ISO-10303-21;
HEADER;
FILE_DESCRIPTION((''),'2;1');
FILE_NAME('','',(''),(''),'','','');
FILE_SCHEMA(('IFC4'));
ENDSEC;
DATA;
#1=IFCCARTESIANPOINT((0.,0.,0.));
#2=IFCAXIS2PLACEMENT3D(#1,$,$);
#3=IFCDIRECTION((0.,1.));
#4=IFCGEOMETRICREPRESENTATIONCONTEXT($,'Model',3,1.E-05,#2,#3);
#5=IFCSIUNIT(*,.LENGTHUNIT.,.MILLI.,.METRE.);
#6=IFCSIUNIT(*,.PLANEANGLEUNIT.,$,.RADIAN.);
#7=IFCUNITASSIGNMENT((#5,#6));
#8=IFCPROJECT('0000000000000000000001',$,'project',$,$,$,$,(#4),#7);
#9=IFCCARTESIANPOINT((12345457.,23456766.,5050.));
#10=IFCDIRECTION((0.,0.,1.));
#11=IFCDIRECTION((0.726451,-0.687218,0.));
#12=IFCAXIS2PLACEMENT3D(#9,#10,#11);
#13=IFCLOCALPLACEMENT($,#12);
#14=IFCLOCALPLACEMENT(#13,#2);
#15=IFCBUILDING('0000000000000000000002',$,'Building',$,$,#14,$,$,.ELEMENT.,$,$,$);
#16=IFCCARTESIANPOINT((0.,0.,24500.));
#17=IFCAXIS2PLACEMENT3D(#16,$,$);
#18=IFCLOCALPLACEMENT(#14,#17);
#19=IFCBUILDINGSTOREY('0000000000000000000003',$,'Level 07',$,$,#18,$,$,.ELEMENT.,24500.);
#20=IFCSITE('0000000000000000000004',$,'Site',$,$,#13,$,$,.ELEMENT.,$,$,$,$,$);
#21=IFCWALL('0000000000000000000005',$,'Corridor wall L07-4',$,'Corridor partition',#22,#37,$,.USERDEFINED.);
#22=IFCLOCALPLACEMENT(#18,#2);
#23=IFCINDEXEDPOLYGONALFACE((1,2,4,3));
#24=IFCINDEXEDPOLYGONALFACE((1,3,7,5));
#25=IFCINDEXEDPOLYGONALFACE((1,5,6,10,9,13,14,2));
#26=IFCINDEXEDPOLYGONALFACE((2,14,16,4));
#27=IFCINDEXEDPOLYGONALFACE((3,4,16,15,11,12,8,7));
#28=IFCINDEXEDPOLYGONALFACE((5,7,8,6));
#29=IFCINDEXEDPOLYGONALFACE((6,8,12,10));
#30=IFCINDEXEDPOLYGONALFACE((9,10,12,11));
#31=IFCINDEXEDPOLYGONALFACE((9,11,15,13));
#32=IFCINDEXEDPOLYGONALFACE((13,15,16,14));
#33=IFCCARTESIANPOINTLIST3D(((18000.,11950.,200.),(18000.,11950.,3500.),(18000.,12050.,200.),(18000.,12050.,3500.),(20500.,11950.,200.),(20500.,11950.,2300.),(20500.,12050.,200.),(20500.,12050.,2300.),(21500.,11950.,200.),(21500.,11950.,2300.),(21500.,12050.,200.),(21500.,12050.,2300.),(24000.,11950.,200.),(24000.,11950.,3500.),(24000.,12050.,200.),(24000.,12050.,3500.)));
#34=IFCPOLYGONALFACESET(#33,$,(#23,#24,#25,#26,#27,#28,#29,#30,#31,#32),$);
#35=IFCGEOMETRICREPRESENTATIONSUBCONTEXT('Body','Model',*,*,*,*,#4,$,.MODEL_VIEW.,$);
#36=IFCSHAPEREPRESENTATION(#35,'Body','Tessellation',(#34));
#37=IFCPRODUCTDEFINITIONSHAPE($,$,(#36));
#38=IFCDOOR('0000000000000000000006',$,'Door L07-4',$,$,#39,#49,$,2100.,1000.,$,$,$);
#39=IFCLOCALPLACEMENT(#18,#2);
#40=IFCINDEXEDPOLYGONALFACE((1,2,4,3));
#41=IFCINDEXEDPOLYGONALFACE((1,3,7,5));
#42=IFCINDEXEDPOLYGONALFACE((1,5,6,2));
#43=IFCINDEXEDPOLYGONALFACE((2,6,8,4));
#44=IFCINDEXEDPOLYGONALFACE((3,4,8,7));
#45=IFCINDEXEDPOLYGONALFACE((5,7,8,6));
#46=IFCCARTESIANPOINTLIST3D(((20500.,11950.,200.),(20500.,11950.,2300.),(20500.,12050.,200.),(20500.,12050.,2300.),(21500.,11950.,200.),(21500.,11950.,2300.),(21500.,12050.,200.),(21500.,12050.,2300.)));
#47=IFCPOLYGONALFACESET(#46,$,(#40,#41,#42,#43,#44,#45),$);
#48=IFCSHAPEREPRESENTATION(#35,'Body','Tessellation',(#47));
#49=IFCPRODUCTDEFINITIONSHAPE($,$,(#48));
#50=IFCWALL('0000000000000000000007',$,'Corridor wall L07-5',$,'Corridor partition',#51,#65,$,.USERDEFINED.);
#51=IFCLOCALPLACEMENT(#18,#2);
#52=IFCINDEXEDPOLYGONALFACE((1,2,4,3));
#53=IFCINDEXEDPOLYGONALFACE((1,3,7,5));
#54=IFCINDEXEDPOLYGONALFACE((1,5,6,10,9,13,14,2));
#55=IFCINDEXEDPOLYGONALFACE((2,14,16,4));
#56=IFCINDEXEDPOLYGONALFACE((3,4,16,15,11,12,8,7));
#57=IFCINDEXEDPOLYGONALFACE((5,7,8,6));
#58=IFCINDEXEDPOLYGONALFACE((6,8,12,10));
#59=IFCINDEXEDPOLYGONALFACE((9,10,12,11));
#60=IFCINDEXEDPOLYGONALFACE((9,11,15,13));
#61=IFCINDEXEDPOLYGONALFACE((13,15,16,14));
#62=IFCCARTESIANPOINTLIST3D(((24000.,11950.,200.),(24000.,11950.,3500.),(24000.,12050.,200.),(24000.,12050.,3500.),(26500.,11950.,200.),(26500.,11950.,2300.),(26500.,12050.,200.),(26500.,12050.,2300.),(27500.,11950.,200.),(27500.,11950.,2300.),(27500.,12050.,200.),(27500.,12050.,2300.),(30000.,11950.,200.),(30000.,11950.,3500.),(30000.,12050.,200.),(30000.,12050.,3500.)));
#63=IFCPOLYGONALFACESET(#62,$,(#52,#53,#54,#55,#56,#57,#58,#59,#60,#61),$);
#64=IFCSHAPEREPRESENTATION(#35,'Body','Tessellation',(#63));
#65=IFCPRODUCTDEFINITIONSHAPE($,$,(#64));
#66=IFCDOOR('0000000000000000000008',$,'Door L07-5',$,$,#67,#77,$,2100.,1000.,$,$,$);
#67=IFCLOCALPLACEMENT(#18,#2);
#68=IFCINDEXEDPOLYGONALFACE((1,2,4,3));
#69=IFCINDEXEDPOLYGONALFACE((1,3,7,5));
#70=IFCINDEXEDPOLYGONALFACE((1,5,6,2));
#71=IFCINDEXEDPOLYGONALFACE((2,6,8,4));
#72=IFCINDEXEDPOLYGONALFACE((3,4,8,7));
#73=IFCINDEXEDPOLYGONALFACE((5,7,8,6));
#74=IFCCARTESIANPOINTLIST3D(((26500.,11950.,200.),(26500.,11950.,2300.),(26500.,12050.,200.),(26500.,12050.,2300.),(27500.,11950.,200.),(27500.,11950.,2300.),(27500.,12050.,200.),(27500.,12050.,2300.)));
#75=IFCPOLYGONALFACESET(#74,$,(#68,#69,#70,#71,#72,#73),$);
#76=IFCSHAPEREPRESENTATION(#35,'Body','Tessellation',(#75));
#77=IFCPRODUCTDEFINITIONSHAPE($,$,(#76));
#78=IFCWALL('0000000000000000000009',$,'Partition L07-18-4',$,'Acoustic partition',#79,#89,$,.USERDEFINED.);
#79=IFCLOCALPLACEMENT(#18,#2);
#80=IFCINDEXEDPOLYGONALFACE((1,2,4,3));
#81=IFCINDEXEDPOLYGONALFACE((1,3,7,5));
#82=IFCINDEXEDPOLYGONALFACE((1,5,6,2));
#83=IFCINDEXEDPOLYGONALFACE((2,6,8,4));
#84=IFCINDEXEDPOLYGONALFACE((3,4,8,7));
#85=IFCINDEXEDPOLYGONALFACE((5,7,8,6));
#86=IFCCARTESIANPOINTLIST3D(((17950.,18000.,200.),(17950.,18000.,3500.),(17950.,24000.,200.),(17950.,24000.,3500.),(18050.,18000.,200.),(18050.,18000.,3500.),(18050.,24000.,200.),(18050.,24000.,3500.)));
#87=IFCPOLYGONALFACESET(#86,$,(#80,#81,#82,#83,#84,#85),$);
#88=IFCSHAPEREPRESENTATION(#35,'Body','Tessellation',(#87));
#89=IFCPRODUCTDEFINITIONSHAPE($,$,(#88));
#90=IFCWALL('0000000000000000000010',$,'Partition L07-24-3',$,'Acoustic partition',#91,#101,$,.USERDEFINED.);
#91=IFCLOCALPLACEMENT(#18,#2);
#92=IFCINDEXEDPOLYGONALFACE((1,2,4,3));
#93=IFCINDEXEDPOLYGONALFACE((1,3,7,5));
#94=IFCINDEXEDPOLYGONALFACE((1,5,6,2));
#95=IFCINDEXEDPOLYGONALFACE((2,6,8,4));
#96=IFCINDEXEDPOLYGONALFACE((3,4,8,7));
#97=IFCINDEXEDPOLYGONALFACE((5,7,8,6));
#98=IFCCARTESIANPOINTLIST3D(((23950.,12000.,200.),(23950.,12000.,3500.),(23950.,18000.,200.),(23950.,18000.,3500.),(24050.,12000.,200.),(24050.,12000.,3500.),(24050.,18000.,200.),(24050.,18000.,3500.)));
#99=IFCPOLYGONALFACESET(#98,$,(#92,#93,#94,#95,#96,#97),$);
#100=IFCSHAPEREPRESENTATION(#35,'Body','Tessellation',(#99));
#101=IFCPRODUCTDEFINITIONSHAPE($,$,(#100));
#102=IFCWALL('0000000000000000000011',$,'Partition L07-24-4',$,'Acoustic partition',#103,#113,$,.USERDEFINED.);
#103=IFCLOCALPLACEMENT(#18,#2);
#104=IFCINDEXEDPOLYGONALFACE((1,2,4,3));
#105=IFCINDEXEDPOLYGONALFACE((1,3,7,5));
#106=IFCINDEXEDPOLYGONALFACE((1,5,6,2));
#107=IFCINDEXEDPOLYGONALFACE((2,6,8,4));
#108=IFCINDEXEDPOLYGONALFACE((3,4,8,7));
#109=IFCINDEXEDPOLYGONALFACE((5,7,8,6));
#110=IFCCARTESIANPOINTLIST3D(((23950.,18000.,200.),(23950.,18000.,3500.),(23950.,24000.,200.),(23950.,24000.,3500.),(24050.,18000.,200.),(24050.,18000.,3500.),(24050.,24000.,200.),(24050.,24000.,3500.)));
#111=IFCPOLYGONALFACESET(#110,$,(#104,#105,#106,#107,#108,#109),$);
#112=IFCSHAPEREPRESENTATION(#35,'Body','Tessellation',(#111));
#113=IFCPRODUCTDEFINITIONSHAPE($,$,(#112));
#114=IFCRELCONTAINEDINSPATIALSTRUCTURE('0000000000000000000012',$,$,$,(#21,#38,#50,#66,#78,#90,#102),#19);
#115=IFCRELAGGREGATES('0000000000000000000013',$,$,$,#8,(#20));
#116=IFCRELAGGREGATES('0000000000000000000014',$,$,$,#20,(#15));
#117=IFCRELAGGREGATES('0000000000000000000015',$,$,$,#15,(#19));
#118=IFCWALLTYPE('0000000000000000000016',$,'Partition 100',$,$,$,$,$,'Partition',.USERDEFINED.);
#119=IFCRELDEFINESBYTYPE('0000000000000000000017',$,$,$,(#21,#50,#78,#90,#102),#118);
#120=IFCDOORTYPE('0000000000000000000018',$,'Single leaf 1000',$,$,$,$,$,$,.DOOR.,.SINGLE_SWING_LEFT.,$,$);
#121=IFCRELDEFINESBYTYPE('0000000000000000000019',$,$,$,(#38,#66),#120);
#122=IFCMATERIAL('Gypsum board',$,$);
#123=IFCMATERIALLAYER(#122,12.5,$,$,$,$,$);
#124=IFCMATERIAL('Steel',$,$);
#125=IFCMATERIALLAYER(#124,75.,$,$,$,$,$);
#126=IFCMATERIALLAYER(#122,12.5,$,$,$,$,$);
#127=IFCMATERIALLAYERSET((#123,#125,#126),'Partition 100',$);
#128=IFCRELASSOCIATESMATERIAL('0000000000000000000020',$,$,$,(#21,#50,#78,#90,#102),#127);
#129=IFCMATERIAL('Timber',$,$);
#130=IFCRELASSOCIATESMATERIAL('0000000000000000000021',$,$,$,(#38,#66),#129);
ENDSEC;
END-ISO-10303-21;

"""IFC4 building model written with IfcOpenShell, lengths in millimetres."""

from ifc_helpers import new_model, si_unit, direction, frame, origin, place, context, subcontext, project, spatial, rectangle, extrude, source, transform, mapped, material, layer, layer_set, layer_usage, type_object, type_shapes, element, fill, save


model = new_model("IFC4")

# Units and contexts
model_context = context("Model", 3, precision=1e-05, world=origin(), true_north=direction((0.0, 1.0)))
body_context = subcontext(model_context, "Body", "Model", "MODEL_VIEW")
ifc_project = project(units=[si_unit("LENGTHUNIT", "METRE", prefix="MILLI"), si_unit("PLANEANGLEUNIT", "RADIAN")], contexts=[model_context])

# Site, building, storey
site_placement = place(None, frame((12345457.0, 23456766.0, 5050.0), z_axis=(0.0, 0.0, 1.0), x_axis=(0.726451, -0.687218, 0.0)))
site = spatial("IfcSite", under=ifc_project, at=site_placement, Name="Site", CompositionType="ELEMENT")
building_placement = place(site_placement, origin())
building = spatial("IfcBuilding", under=site, at=building_placement, Name="Building", CompositionType="ELEMENT")
storey_placement = place(building_placement, frame((0.0, 0.0, 24500.0)))
storey = spatial("IfcBuildingStorey", under=building, at=storey_placement, Name="Level 07", CompositionType="ELEMENT", Elevation=24500.0)

# Shared definitions
ifc_material_1 = material(Name="Steel")

# Walls, openings, doors
ifc_material_2 = material(Name="Gypsum board")
ifc_layer_1 = layer(ifc_material_2, 12.5)
ifc_layer_2 = layer(ifc_material_1, 75.0)
ifc_layer_3 = layer(ifc_material_2, 12.5)
ifc_layer_set_1 = layer_set([ifc_layer_1, ifc_layer_2, ifc_layer_3], Name="Partition 100")
ifc_layer_usage_1 = layer_usage(ifc_layer_set_1, "AXIS2", "POSITIVE", 0.0)
wall_type_1 = type_object("IfcWallType", Name="Partition 100", ElementType="Partition", PredefinedType="USERDEFINED")
wall_1_placement = place(storey_placement, frame((18000.0, 11950.0, 200.0)))
wall_1 = element("IfcWall", 1, at=wall_1_placement, inside=storey, type_object=wall_type_1, material=ifc_layer_usage_1, Name="Corridor wall L07-4", ObjectType="Corridor partition", PredefinedType="USERDEFINED", context=body_context, shape_type="SweptSolid", body=[
    extrude(rectangle(XDim=6000.0, YDim=100.0), frame((3000.0, 50.0, 0.0)), (0.0, 0.0, 1.0), 3300.0),
])
opening_1_placement = place(wall_1_placement, frame((2500.0, -50.0, 0.0)))
opening_1 = element("IfcOpeningElement", 2, at=opening_1_placement, cuts=wall_1, PredefinedType="OPENING", context=body_context, shape_type="SweptSolid", body=[
    extrude(rectangle(XDim=1000.0, YDim=200.0), frame((500.0, 100.0, 0.0)), (0.0, 0.0, 1.0), 2100.0),
])
ifc_material_3 = material(Name="Timber")
door_type = type_object("IfcDoorType", Name="Single leaf 1000", OperationType="SINGLE_SWING_LEFT", PredefinedType="DOOR")
shared_shape = source(origin(), body_context, "Body", "SweptSolid", [
    extrude(rectangle(XDim=1000.0, YDim=100.0), frame((500.0, 50.0, 0.0)), (0.0, 0.0, 1.0), 2100.0),
])
type_shapes(door_type, [shared_shape])
door_1_placement = place(storey_placement, frame((20500.0, 11950.0, 200.0)))
door_1 = element("IfcDoor", 3, at=door_1_placement, inside=storey, type_object=door_type, material=ifc_material_3, Name="Door L07-4", OverallHeight=2100.0, OverallWidth=1000.0, context=body_context, shape_type="MappedRepresentation", body=[
    mapped(shared_shape, transform((0.0, 0.0, 0.0))),
])
fill(opening_1, door_1)
wall_2_placement = place(storey_placement, frame((24000.0, 11950.0, 200.0)))
wall_2 = element("IfcWall", 4, at=wall_2_placement, inside=storey, type_object=wall_type_1, material=ifc_layer_usage_1, Name="Corridor wall L07-5", ObjectType="Corridor partition", PredefinedType="USERDEFINED", context=body_context, shape_type="SweptSolid", body=[
    extrude(rectangle(XDim=6000.0, YDim=100.0), frame((3000.0, 50.0, 0.0)), (0.0, 0.0, 1.0), 3300.0),
])
opening_2_placement = place(wall_2_placement, frame((2500.0, -50.0, 0.0)))
opening_2 = element("IfcOpeningElement", 5, at=opening_2_placement, cuts=wall_2, PredefinedType="OPENING", context=body_context, shape_type="SweptSolid", body=[
    extrude(rectangle(XDim=1000.0, YDim=200.0), frame((500.0, 100.0, 0.0)), (0.0, 0.0, 1.0), 2100.0),
])
door_2_placement = place(storey_placement, frame((26500.0, 11950.0, 200.0)))
door_2 = element("IfcDoor", 6, at=door_2_placement, inside=storey, type_object=door_type, material=ifc_material_3, Name="Door L07-5", OverallHeight=2100.0, OverallWidth=1000.0, context=body_context, shape_type="MappedRepresentation", body=[
    mapped(shared_shape, transform((0.0, 0.0, 0.0))),
])
fill(opening_2, door_2)

# Walls
for number, where, name in (
    (7, (17950.0, 18000.0, 200.0), "Partition L07-18-4"),
    (8, (23950.0, 12000.0, 200.0), "Partition L07-24-3"),
    (9, (23950.0, 18000.0, 200.0), "Partition L07-24-4"),
):
    element("IfcWall", number, at=place(storey_placement, frame(where)), inside=storey, type_object=wall_type_1, material=ifc_layer_usage_1, Name=name, ObjectType="Acoustic partition", PredefinedType="USERDEFINED", context=body_context, shape_type="SweptSolid", body=[
        extrude(rectangle(XDim=100.0, YDim=6000.0), frame((50.0, 3000.0, 0.0)), (0.0, 0.0, 1.0), 3300.0),
    ])

save(model, "model.ifc")
